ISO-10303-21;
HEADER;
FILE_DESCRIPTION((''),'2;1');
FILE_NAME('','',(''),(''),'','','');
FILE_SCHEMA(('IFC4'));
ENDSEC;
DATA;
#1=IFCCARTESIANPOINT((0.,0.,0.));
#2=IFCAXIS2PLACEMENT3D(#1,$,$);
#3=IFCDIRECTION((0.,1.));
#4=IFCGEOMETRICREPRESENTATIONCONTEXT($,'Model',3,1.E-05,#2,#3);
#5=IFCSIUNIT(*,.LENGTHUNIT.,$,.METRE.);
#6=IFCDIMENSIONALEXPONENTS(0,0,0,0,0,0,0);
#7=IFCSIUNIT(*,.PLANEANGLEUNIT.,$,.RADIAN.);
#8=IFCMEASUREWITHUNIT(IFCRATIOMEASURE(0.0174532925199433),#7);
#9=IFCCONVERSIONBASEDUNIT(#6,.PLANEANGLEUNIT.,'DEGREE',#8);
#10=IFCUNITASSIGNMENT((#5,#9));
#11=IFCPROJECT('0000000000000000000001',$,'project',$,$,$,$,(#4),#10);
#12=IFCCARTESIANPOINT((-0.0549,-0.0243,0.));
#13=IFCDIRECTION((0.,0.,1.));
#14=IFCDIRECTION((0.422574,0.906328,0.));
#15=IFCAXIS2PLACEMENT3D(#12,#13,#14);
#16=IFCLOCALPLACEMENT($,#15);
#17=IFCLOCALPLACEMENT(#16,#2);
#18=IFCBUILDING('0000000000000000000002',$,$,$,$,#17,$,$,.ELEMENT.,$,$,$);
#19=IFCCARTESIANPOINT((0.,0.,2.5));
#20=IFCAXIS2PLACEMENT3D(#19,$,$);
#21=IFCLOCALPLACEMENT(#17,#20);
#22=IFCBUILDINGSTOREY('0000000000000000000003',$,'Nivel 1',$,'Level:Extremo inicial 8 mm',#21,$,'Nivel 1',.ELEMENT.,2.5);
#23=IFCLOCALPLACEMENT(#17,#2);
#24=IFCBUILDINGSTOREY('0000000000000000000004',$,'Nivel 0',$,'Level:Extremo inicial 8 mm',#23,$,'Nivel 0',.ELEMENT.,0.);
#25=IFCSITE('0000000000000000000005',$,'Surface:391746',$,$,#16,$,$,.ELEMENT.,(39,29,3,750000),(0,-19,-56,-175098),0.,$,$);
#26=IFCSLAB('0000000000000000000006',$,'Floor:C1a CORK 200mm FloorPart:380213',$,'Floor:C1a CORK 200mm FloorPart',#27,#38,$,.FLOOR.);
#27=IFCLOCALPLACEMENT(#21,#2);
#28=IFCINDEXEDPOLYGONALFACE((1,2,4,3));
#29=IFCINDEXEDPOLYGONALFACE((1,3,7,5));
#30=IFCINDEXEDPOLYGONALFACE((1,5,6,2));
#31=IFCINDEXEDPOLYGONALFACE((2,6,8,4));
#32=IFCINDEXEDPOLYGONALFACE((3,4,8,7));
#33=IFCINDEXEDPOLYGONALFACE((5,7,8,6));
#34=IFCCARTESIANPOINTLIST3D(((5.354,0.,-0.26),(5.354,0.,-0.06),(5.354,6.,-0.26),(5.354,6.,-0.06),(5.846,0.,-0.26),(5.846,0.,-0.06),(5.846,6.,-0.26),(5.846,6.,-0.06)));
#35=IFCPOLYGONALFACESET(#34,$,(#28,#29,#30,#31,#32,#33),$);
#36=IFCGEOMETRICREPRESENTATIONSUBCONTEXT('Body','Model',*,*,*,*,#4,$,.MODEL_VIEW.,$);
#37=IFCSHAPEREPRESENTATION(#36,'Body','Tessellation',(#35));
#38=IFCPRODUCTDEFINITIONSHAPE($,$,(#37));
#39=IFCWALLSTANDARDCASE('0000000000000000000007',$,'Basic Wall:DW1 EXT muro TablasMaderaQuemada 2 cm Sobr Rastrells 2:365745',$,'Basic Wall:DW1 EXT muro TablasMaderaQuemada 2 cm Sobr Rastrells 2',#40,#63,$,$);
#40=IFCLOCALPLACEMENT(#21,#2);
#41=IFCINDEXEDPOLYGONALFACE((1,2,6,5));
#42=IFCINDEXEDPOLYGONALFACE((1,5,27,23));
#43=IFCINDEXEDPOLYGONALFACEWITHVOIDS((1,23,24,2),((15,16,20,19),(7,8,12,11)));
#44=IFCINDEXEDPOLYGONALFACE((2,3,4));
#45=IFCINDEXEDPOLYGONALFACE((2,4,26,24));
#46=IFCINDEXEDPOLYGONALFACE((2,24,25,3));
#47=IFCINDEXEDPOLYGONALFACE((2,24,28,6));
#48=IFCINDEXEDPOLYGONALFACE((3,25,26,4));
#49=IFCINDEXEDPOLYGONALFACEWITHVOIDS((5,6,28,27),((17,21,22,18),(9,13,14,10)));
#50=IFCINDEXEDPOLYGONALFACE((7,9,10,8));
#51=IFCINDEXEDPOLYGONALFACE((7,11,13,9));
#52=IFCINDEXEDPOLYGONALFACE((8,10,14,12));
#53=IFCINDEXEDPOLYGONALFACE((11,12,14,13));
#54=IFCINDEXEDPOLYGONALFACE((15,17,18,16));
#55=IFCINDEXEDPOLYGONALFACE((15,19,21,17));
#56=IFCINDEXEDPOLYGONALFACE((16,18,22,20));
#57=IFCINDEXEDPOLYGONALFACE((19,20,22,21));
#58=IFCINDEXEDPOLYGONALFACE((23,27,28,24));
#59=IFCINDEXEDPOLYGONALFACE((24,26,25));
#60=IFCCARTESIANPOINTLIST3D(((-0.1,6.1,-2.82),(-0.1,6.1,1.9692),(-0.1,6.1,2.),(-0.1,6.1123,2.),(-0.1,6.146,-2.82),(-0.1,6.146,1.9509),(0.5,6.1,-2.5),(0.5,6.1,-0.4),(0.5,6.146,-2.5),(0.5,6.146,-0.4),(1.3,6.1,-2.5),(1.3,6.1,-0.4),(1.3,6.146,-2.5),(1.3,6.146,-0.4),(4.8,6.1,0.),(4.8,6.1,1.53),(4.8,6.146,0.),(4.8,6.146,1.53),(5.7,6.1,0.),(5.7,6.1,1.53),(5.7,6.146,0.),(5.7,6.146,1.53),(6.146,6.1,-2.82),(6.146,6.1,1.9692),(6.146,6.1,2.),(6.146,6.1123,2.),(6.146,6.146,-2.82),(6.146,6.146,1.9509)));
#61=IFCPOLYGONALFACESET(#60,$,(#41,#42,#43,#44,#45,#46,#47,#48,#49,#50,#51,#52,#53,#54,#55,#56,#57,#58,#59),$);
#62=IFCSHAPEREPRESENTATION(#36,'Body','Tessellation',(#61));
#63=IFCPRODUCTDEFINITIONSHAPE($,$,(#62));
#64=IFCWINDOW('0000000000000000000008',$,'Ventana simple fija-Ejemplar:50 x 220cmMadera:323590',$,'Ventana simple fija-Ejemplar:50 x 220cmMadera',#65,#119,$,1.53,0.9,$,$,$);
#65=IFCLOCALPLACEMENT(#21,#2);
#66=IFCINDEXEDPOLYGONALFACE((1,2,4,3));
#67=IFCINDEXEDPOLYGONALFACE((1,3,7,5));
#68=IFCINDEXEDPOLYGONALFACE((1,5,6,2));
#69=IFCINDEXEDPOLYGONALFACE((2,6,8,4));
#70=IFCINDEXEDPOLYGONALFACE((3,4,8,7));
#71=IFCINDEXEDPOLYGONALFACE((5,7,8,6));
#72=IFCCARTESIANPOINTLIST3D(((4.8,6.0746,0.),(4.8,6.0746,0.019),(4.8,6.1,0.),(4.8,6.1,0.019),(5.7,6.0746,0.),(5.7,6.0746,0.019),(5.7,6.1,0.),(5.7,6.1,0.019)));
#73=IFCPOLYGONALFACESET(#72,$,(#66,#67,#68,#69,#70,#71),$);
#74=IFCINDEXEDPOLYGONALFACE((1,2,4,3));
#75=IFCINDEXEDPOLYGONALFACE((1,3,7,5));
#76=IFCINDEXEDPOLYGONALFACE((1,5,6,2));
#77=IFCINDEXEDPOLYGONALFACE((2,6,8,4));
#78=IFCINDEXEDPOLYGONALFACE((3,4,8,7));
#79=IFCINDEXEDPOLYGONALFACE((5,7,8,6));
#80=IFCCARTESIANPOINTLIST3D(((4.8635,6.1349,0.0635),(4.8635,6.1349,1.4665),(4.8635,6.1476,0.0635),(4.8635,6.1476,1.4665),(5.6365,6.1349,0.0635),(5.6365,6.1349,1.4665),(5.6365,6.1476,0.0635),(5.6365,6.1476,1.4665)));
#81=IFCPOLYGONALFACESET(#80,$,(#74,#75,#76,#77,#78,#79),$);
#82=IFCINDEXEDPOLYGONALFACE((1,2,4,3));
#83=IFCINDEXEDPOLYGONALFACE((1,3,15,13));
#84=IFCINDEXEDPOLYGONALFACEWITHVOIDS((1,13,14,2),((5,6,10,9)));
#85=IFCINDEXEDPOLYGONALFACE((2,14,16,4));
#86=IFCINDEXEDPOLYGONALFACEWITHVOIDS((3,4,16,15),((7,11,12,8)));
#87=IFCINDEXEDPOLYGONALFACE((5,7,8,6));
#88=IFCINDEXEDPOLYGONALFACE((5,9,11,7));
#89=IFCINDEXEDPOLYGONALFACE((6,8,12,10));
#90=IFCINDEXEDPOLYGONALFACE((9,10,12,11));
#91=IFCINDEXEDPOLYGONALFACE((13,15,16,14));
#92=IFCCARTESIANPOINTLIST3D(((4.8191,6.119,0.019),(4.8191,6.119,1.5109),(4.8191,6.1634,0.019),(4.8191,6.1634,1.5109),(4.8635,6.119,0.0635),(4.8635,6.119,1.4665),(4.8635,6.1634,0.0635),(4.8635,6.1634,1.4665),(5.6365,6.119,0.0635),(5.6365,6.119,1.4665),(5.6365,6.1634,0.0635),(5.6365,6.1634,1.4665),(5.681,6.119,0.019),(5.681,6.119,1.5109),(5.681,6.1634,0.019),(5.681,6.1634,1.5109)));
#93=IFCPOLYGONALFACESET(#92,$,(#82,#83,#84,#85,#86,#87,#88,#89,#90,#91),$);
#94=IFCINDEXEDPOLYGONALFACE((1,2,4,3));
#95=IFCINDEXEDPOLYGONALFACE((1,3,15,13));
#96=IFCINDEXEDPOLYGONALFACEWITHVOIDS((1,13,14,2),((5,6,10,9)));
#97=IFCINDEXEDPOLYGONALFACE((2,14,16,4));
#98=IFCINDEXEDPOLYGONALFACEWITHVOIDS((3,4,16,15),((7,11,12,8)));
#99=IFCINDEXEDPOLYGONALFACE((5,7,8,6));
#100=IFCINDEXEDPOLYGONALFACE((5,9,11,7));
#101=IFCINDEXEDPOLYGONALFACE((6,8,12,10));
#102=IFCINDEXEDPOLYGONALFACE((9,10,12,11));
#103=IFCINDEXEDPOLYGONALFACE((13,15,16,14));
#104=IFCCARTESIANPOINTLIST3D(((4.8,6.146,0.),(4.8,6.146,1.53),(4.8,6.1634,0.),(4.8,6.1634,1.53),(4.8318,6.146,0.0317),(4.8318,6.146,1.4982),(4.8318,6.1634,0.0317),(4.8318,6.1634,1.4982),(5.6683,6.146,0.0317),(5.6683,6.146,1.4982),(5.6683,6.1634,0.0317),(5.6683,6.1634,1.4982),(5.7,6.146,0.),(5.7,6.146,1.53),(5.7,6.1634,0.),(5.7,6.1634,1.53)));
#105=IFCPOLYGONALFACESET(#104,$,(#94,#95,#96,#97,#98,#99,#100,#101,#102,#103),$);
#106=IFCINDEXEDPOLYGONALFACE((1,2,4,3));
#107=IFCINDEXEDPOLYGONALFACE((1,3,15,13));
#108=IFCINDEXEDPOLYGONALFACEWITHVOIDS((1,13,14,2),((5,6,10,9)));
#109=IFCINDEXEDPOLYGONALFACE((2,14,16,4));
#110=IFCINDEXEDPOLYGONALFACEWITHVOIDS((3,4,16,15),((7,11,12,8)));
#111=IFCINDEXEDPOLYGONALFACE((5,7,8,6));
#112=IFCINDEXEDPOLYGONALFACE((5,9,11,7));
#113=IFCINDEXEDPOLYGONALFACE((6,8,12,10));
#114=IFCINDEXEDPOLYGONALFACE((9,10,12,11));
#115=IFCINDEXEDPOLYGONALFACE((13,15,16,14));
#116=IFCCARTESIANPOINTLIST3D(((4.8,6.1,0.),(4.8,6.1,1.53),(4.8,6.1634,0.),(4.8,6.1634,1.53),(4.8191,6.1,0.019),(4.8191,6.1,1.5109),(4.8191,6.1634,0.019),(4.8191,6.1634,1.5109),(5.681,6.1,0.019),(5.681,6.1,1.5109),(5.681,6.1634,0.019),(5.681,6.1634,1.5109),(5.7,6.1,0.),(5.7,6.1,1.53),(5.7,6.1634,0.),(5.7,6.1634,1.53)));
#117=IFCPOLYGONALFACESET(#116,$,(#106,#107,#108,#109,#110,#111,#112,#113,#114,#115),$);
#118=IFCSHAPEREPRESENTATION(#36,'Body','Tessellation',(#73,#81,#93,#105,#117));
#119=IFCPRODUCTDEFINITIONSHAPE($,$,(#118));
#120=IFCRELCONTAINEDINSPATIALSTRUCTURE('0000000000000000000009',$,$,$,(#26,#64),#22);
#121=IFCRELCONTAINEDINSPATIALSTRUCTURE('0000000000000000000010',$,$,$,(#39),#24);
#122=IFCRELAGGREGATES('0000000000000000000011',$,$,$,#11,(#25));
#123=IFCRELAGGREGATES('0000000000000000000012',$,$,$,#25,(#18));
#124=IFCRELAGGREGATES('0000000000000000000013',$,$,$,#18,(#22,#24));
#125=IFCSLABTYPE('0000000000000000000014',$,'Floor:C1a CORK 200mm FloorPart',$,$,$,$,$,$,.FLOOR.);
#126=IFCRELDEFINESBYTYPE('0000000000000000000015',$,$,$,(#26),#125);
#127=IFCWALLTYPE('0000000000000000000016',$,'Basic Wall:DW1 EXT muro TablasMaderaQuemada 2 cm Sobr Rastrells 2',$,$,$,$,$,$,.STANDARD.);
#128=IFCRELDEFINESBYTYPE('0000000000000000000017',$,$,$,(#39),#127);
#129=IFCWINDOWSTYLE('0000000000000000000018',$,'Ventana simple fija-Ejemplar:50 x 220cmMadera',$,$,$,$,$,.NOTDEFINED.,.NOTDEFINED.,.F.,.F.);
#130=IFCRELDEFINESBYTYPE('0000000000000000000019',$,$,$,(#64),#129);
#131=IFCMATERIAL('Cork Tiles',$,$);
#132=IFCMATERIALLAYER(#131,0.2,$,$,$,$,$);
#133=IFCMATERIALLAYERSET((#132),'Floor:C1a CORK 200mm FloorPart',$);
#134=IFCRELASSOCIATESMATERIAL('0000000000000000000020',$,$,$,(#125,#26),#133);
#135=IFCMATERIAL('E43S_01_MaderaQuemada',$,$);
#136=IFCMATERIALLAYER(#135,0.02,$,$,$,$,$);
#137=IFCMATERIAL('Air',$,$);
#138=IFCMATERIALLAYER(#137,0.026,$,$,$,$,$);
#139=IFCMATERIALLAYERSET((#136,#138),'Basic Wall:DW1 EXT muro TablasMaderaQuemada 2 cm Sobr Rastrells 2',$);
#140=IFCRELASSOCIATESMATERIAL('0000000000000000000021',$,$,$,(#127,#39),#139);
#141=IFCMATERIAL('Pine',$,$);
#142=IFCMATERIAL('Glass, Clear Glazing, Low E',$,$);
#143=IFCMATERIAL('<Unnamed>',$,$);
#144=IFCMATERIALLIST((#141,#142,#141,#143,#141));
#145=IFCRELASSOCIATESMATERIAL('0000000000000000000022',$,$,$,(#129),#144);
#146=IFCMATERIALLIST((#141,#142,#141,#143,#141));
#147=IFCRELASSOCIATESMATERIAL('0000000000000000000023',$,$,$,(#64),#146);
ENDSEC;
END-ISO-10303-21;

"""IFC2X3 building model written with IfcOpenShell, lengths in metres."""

from ifc_helpers import new_model, entity, si_unit, converted_unit, direction, frame, frame_2d, origin, origin_2d_with_axis, place, context, subcontext, project, spatial, polyline, rectangle, outline, extrude, source, transform, mapped, material, material_list, layer, layer_set, layer_usage, type_object, type_shapes, element, fill, save


model = new_model("IFC2X3")

# Units and contexts
model_context = context("Model", 3, precision=1e-05, world=origin(), true_north=direction((0.0, 1.0)))
body_context = subcontext(model_context, "Body", "Model", "MODEL_VIEW")
ifc_project = project(units=[si_unit("LENGTHUNIT", "METRE"), converted_unit("PLANEANGLEUNIT", "DEGREE", entity("IfcRatioMeasure", 0.0174532925199433), si_unit("PLANEANGLEUNIT", "RADIAN"), dimensions=[0, 0, 0, 0, 0, 0, 0])], contexts=[model_context])

# Site, building, storey
site_placement = place(None, frame((-0.0549, -0.0243, 0.0), z_axis=(0.0, 0.0, 1.0), x_axis=(0.422574, 0.906328, 0.0)))
site = spatial("IfcSite", under=ifc_project, at=site_placement, Name="Surface:391746", CompositionType="ELEMENT", RefLatitude=(39, 29, 3, 750000), RefLongitude=(0, -19, -56, -175098), RefElevation=0.0)
building_placement = place(site_placement, origin())
building = spatial("IfcBuilding", under=site, at=building_placement, CompositionType="ELEMENT")
storey_1_placement = place(building_placement, frame((0.0, 0.0, 2.5)))
storey_1 = spatial("IfcBuildingStorey", under=building, at=storey_1_placement, Name="Nivel 1", ObjectType="Level:Extremo inicial 8 mm", LongName="Nivel 1", CompositionType="ELEMENT", Elevation=2.5)

# Slab
ifc_material_1 = material(Name="Cork Tiles")
ifc_layer_1 = layer(ifc_material_1, 0.2)
ifc_layer_set_1 = layer_set([ifc_layer_1], Name="Floor:C1a CORK 200mm FloorPart")
ifc_layer_usage_1 = layer_usage(ifc_layer_set_1, "AXIS3", "POSITIVE", 0.0)
slab_type_1 = type_object("IfcSlabType", Name="Floor:C1a CORK 200mm FloorPart", PredefinedType="FLOOR", material=ifc_layer_set_1)
slab_1_placement = place(storey_1_placement, origin())
element("IfcSlab", 1, at=slab_1_placement, inside=storey_1, type_object=slab_type_1, material=ifc_layer_usage_1, Name="Floor:C1a CORK 200mm FloorPart:380213", ObjectType="Floor:C1a CORK 200mm FloorPart", PredefinedType="FLOOR", context=body_context, shape_type="SweptSolid", body=[
    extrude(rectangle(XDim=6.0, YDim=0.492, at=frame_2d((0.0, 0.0), x_axis=(1.0, 0.0))), frame((5.6, 3.0, -0.06), z_axis=(0.0, 0.0, -1.0), x_axis=(0.0, 1.0, 0.0)), (0.0, 0.0, 1.0), 0.2),
])

# Shared definitions
storey_2_placement = place(building_placement, origin())
storey_2 = spatial("IfcBuildingStorey", under=building, at=storey_2_placement, Name="Nivel 0", ObjectType="Level:Extremo inicial 8 mm", LongName="Nivel 0", CompositionType="ELEMENT", Elevation=0.0)

# Wall, openings, window
ifc_material_2 = material(Name="E43S_01_MaderaQuemada")
ifc_layer_2 = layer(ifc_material_2, 0.02)
ifc_material_3 = material(Name="Air")
ifc_layer_3 = layer(ifc_material_3, 0.026)
ifc_layer_set_2 = layer_set([ifc_layer_2, ifc_layer_3], Name="Basic Wall:DW1 EXT muro TablasMaderaQuemada 2 cm Sobr Rastrells 2")
ifc_layer_usage_2 = layer_usage(ifc_layer_set_2, "AXIS2", "NEGATIVE", 0.023)
wall_type = type_object("IfcWallType", Name="Basic Wall:DW1 EXT muro TablasMaderaQuemada 2 cm Sobr Rastrells 2", PredefinedType="STANDARD", material=ifc_layer_set_2)
wall_placement = place(storey_2_placement, frame((-0.1, 6.123, -0.32)))
wall = element("IfcWallStandardCase", 2, at=wall_placement, inside=storey_2, type_object=wall_type, material=ifc_layer_usage_2, Name="Basic Wall:DW1 EXT muro TablasMaderaQuemada 2 cm Sobr Rastrells 2:365745", ObjectType="Basic Wall:DW1 EXT muro TablasMaderaQuemada 2 cm Sobr Rastrells 2", context=body_context, shape_type="SweptSolid", body=[
    extrude(rectangle(XDim=6.246, YDim=0.046, at=frame_2d((3.123, 0.0), x_axis=(-1.0, 0.0))), origin(), (0.0, 0.0, 1.0), 4.82),
])
opening_1_placement = place(storey_2_placement, frame((-0.1, 6.123, -0.32)))
element("IfcOpeningElement", 3, at=opening_1_placement, cuts=wall, ObjectType="Opening", context=body_context, shape_type="SweptSolid", body=[
    extrude(rectangle(XDim=0.0495, YDim=6.246, at=frame_2d((-0.6154, 0.005), x_axis=(0.0, 1.0))), frame((3.7384, -0.0046, 4.7819), z_axis=(0.0, 0.370288, 0.928917), x_axis=(1.0, 0.0, 0.0)), (0.0, 0.0, 1.0), 0.0599),
])
opening_2_placement = place(wall_placement, origin())
element("IfcOpeningElement", 4, at=opening_2_placement, cuts=wall, ObjectType="Opening", context=body_context, shape_type="SweptSolid", body=[
    extrude(rectangle(XDim=2.1, YDim=0.8, at=frame_2d((0.0, 0.0), x_axis=(1.0, 0.0))), frame((1.0, -1.547, 1.37), z_axis=(0.0, 1.0, 0.0), x_axis=(0.0, 0.0, -1.0)), (0.0, 0.0, 1.0), 3.048),
])
opening_3_placement = place(wall_placement, frame((5.8, 0.023, 2.82)))
opening_3 = element("IfcOpeningElement", 5, at=opening_3_placement, cuts=wall, ObjectType="Opening", context=body_context, shape_type="SweptSolid", body=[
    extrude(rectangle(XDim=1.53, YDim=0.9, at=frame_2d((0.765, 0.45), x_axis=(-1.0, 0.0))), frame((0.0, 0.0, 0.0), z_axis=(0.0, -1.0, 0.0), x_axis=(0.0, 0.0, 1.0)), (0.0, 0.0, 1.0), 0.046),
])
ifc_material_4 = material(Name="Pine")
ifc_material_5 = material(Name="Glass, Clear Glazing, Low E")
ifc_material_6 = material(Name="<Unnamed>")
ifc_material_list_1 = material_list([ifc_material_4, ifc_material_5, ifc_material_4, ifc_material_6, ifc_material_4])
ifc_material_list_2 = material_list([ifc_material_4, ifc_material_5, ifc_material_4, ifc_material_6, ifc_material_4])
window_style = type_object("IfcWindowStyle", Name="Ventana simple fija-Ejemplar:50 x 220cmMadera", ConstructionType="NOTDEFINED", OperationType="NOTDEFINED", ParameterTakesPrecedence=False, Sizeable=False, material=ifc_material_list_2)
shared_shape = source(origin(), body_context, "Body", "SweptSolid", [
    extrude(rectangle(XDim=0.9, YDim=0.0254, at=origin_2d_with_axis()), frame((0.5262, 0.0587, 0.0), z_axis=(0.0, 0.0, 1.0), x_axis=(-1.0, 0.0, 0.0)), (0.0, 0.0, 1.0), 0.019),
    extrude(rectangle(XDim=0.773, YDim=0.0127, at=origin_2d_with_axis()), frame((0.5262, 0.0048, 0.0635)), (0.0, 0.0, 1.0), 1.403),
    extrude(outline(polyline([(-0.431, -0.7459), (0.431, -0.7459), (0.431, 0.7459), (-0.431, 0.7459), (-0.431, -0.7459)]), holes=[polyline([(-0.3865, -0.7015), (-0.3865, 0.7015), (0.3865, 0.7015), (0.3865, -0.7015), (-0.3865, -0.7015)])]), frame((0.5262, 0.027, 0.765), z_axis=(0.0, -1.0, 0.0), x_axis=(-1.0, 0.0, 0.0)), (0.0, 0.0, 1.0), 0.0445),
    extrude(outline(polyline([(-0.45, -0.765), (0.45, -0.765), (0.45, 0.765), (-0.45, 0.765), (-0.45, -0.765)]), holes=[polyline([(-0.4183, -0.7332), (-0.4183, 0.7332), (0.4183, 0.7332), (0.4183, -0.7332), (-0.4183, -0.7332)])]), frame((0.5262, 0.0, 0.765), z_axis=(0.0, -1.0, 0.0), x_axis=(-1.0, 0.0, 0.0)), (0.0, 0.0, 1.0), 0.0175),
    extrude(outline(polyline([(-0.765, -0.45), (0.765, -0.45), (0.765, 0.45), (-0.765, 0.45), (-0.765, -0.45)]), holes=[polyline([(-0.7459, -0.431), (-0.7459, 0.431), (0.7459, 0.431), (0.7459, -0.431), (-0.7459, -0.431)])]), frame((0.5262, 0.046, 0.765), z_axis=(0.0, -1.0, 0.0), x_axis=(0.0, 0.0, -1.0)), (0.0, 0.0, 1.0), 0.0635),
])
type_shapes(window_style, [shared_shape])
window_placement = place(opening_3_placement, frame((0.0762, 0.0, 0.0), z_axis=(0.0, 0.0, 1.0), x_axis=(-1.0, 0.0, 0.0)))
window = element("IfcWindow", 6, at=window_placement, inside=storey_1, type_object=window_style, material=ifc_material_list_1, Name="Ventana simple fija-Ejemplar:50 x 220cmMadera:323590", ObjectType="Ventana simple fija-Ejemplar:50 x 220cmMadera", OverallHeight=1.53, OverallWidth=0.9, context=body_context, shape_type="MappedRepresentation", body=[
    mapped(shared_shape, transform((0.0, 0.0, 0.0), scale=1.0)),
])
fill(opening_3, window)

save(model, "model.ifc")
